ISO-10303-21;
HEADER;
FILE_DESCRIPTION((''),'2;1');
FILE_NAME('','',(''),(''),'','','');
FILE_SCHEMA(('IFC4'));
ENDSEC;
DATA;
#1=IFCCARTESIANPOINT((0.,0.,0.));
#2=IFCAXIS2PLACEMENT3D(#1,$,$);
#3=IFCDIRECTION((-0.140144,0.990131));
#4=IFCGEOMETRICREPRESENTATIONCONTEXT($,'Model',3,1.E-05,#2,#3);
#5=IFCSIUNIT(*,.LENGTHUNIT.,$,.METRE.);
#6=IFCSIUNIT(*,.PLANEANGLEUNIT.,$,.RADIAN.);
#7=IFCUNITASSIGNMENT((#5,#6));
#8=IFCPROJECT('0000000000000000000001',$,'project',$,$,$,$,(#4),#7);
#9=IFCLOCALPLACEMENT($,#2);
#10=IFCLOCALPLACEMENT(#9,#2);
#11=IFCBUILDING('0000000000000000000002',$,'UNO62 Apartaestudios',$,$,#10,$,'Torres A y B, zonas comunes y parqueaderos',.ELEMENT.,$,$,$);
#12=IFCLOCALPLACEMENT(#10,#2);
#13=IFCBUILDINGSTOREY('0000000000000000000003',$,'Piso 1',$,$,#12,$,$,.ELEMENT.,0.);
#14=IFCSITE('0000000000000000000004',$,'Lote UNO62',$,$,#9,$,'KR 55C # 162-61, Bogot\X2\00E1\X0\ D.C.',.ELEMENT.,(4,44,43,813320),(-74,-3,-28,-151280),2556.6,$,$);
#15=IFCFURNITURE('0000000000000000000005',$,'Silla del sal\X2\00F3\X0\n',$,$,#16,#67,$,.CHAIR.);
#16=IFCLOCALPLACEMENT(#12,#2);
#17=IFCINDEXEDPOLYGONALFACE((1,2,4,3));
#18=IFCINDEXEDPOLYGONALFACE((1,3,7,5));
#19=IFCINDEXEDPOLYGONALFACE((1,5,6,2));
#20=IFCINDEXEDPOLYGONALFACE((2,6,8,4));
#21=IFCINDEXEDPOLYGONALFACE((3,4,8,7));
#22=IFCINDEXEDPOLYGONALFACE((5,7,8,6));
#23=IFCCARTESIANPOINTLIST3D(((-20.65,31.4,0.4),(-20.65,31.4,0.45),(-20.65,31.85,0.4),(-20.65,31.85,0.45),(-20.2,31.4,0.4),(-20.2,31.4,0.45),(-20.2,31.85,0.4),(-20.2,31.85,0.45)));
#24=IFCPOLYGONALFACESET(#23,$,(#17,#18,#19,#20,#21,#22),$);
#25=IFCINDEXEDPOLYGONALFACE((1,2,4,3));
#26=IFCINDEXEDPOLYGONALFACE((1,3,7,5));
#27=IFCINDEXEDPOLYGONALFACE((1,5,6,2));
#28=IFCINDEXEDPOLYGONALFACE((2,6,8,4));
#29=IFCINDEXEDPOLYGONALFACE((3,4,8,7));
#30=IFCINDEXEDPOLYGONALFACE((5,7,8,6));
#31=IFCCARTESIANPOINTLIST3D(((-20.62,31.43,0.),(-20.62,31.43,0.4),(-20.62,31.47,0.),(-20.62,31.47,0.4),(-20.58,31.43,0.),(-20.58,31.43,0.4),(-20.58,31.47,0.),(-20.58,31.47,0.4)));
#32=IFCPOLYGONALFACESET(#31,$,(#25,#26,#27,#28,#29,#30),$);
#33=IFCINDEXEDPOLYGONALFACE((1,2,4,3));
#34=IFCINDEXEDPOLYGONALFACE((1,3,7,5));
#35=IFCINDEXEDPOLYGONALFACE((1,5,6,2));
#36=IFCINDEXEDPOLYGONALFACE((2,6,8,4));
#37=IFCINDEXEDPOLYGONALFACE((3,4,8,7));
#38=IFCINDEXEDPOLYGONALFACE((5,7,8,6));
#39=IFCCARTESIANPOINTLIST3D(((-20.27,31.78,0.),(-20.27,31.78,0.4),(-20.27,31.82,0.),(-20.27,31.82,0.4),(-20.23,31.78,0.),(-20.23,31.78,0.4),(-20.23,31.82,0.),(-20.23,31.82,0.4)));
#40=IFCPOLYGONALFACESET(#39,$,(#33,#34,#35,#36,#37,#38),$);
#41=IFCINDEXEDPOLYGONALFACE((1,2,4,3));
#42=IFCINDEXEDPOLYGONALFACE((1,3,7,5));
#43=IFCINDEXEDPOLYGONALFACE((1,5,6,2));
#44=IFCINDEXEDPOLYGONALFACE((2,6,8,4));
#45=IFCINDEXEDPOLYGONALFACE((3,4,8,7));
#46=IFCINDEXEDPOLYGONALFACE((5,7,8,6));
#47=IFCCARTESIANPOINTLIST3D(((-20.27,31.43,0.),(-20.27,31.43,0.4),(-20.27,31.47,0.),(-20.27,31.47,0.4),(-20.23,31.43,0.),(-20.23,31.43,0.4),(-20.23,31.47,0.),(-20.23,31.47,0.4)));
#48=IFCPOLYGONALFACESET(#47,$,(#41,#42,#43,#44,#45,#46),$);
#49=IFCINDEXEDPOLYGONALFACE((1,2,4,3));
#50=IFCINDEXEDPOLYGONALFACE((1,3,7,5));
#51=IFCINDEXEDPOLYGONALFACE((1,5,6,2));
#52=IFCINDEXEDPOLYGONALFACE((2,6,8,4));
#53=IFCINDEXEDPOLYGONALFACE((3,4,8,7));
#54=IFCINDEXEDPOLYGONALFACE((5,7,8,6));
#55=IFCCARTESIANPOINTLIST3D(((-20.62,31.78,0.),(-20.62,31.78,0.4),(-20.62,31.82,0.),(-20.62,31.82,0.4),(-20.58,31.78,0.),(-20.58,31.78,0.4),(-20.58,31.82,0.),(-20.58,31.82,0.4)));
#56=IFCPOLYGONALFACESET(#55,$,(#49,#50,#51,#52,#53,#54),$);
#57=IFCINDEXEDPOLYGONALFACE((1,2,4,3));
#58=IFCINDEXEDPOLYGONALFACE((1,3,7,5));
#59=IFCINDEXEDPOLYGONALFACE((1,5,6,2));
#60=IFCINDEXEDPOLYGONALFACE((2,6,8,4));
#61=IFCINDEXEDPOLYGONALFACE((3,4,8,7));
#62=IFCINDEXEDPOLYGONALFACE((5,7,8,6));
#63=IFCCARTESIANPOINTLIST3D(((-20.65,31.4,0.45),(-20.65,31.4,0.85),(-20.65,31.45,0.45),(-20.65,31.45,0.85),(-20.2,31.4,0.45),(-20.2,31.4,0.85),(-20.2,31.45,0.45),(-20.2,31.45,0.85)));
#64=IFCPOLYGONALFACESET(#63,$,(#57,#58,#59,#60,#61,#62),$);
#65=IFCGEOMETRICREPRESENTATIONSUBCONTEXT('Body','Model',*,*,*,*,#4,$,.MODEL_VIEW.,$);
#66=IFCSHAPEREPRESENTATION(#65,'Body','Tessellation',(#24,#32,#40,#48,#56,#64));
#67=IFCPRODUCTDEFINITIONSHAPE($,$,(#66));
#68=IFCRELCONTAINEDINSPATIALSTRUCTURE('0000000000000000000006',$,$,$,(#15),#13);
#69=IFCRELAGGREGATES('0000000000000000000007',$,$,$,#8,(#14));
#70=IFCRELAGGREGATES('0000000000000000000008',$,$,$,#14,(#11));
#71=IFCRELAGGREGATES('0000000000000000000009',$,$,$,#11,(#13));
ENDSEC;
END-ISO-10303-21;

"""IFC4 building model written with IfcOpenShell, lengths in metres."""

from ifc_helpers import new_model, si_unit, direction, frame, frame_2d, origin, place, context, subcontext, project, spatial, rectangle, extrude, element, save


model = new_model("IFC4")

# Units and contexts
model_context = context("Model", 3, precision=1e-05, world=origin(), true_north=direction((-0.140144, 0.990131)))
body_context = subcontext(model_context, "Body", "Model", "MODEL_VIEW")
ifc_project = project(units=[si_unit("LENGTHUNIT", "METRE"), si_unit("PLANEANGLEUNIT", "RADIAN")], contexts=[model_context])

# Site, building, storey
site_placement = place(None, origin())
site = spatial("IfcSite", under=ifc_project, at=site_placement, Name="Lote UNO62", LongName="KR 55C # 162-61, Bogotá D.C.", CompositionType="ELEMENT", RefLatitude=(4, 44, 43, 813320), RefLongitude=(-74, -3, -28, -151280), RefElevation=2556.6)
building_placement = place(site_placement, origin())
building = spatial("IfcBuilding", under=site, at=building_placement, Name="UNO62 Apartaestudios", LongName="Torres A y B, zonas comunes y parqueaderos", CompositionType="ELEMENT")
storey_placement = place(building_placement, origin())
storey = spatial("IfcBuildingStorey", under=building, at=storey_placement, Name="Piso 1", CompositionType="ELEMENT", Elevation=0.0)

# Furniture
furniture_1_placement = place(storey_placement, origin())
element("IfcFurniture", 1, at=furniture_1_placement, inside=storey, Name="Silla del salón", PredefinedType="CHAIR", context=body_context, shape_type="SweptSolid", body=[
    extrude(rectangle(XDim=0.45, YDim=0.45, at=frame_2d((-20.425, 31.625))), frame((0.0, 0.0, 0.4)), (0.0, 0.0, 1.0), 0.05),
    extrude(rectangle(XDim=0.04, YDim=0.04, at=frame_2d((-20.6, 31.45))), origin(), (0.0, 0.0, 1.0), 0.4),
    extrude(rectangle(XDim=0.04, YDim=0.04, at=frame_2d((-20.25, 31.8))), origin(), (0.0, 0.0, 1.0), 0.4),
    extrude(rectangle(XDim=0.04, YDim=0.04, at=frame_2d((-20.25, 31.45))), origin(), (0.0, 0.0, 1.0), 0.4),
    extrude(rectangle(XDim=0.04, YDim=0.04, at=frame_2d((-20.6, 31.8))), origin(), (0.0, 0.0, 1.0), 0.4),
    extrude(rectangle(XDim=0.45, YDim=0.05, at=frame_2d((-20.425, 31.425))), frame((0.0, 0.0, 0.45)), (0.0, 0.0, 1.0), 0.4),
])

save(model, "model.ifc")
